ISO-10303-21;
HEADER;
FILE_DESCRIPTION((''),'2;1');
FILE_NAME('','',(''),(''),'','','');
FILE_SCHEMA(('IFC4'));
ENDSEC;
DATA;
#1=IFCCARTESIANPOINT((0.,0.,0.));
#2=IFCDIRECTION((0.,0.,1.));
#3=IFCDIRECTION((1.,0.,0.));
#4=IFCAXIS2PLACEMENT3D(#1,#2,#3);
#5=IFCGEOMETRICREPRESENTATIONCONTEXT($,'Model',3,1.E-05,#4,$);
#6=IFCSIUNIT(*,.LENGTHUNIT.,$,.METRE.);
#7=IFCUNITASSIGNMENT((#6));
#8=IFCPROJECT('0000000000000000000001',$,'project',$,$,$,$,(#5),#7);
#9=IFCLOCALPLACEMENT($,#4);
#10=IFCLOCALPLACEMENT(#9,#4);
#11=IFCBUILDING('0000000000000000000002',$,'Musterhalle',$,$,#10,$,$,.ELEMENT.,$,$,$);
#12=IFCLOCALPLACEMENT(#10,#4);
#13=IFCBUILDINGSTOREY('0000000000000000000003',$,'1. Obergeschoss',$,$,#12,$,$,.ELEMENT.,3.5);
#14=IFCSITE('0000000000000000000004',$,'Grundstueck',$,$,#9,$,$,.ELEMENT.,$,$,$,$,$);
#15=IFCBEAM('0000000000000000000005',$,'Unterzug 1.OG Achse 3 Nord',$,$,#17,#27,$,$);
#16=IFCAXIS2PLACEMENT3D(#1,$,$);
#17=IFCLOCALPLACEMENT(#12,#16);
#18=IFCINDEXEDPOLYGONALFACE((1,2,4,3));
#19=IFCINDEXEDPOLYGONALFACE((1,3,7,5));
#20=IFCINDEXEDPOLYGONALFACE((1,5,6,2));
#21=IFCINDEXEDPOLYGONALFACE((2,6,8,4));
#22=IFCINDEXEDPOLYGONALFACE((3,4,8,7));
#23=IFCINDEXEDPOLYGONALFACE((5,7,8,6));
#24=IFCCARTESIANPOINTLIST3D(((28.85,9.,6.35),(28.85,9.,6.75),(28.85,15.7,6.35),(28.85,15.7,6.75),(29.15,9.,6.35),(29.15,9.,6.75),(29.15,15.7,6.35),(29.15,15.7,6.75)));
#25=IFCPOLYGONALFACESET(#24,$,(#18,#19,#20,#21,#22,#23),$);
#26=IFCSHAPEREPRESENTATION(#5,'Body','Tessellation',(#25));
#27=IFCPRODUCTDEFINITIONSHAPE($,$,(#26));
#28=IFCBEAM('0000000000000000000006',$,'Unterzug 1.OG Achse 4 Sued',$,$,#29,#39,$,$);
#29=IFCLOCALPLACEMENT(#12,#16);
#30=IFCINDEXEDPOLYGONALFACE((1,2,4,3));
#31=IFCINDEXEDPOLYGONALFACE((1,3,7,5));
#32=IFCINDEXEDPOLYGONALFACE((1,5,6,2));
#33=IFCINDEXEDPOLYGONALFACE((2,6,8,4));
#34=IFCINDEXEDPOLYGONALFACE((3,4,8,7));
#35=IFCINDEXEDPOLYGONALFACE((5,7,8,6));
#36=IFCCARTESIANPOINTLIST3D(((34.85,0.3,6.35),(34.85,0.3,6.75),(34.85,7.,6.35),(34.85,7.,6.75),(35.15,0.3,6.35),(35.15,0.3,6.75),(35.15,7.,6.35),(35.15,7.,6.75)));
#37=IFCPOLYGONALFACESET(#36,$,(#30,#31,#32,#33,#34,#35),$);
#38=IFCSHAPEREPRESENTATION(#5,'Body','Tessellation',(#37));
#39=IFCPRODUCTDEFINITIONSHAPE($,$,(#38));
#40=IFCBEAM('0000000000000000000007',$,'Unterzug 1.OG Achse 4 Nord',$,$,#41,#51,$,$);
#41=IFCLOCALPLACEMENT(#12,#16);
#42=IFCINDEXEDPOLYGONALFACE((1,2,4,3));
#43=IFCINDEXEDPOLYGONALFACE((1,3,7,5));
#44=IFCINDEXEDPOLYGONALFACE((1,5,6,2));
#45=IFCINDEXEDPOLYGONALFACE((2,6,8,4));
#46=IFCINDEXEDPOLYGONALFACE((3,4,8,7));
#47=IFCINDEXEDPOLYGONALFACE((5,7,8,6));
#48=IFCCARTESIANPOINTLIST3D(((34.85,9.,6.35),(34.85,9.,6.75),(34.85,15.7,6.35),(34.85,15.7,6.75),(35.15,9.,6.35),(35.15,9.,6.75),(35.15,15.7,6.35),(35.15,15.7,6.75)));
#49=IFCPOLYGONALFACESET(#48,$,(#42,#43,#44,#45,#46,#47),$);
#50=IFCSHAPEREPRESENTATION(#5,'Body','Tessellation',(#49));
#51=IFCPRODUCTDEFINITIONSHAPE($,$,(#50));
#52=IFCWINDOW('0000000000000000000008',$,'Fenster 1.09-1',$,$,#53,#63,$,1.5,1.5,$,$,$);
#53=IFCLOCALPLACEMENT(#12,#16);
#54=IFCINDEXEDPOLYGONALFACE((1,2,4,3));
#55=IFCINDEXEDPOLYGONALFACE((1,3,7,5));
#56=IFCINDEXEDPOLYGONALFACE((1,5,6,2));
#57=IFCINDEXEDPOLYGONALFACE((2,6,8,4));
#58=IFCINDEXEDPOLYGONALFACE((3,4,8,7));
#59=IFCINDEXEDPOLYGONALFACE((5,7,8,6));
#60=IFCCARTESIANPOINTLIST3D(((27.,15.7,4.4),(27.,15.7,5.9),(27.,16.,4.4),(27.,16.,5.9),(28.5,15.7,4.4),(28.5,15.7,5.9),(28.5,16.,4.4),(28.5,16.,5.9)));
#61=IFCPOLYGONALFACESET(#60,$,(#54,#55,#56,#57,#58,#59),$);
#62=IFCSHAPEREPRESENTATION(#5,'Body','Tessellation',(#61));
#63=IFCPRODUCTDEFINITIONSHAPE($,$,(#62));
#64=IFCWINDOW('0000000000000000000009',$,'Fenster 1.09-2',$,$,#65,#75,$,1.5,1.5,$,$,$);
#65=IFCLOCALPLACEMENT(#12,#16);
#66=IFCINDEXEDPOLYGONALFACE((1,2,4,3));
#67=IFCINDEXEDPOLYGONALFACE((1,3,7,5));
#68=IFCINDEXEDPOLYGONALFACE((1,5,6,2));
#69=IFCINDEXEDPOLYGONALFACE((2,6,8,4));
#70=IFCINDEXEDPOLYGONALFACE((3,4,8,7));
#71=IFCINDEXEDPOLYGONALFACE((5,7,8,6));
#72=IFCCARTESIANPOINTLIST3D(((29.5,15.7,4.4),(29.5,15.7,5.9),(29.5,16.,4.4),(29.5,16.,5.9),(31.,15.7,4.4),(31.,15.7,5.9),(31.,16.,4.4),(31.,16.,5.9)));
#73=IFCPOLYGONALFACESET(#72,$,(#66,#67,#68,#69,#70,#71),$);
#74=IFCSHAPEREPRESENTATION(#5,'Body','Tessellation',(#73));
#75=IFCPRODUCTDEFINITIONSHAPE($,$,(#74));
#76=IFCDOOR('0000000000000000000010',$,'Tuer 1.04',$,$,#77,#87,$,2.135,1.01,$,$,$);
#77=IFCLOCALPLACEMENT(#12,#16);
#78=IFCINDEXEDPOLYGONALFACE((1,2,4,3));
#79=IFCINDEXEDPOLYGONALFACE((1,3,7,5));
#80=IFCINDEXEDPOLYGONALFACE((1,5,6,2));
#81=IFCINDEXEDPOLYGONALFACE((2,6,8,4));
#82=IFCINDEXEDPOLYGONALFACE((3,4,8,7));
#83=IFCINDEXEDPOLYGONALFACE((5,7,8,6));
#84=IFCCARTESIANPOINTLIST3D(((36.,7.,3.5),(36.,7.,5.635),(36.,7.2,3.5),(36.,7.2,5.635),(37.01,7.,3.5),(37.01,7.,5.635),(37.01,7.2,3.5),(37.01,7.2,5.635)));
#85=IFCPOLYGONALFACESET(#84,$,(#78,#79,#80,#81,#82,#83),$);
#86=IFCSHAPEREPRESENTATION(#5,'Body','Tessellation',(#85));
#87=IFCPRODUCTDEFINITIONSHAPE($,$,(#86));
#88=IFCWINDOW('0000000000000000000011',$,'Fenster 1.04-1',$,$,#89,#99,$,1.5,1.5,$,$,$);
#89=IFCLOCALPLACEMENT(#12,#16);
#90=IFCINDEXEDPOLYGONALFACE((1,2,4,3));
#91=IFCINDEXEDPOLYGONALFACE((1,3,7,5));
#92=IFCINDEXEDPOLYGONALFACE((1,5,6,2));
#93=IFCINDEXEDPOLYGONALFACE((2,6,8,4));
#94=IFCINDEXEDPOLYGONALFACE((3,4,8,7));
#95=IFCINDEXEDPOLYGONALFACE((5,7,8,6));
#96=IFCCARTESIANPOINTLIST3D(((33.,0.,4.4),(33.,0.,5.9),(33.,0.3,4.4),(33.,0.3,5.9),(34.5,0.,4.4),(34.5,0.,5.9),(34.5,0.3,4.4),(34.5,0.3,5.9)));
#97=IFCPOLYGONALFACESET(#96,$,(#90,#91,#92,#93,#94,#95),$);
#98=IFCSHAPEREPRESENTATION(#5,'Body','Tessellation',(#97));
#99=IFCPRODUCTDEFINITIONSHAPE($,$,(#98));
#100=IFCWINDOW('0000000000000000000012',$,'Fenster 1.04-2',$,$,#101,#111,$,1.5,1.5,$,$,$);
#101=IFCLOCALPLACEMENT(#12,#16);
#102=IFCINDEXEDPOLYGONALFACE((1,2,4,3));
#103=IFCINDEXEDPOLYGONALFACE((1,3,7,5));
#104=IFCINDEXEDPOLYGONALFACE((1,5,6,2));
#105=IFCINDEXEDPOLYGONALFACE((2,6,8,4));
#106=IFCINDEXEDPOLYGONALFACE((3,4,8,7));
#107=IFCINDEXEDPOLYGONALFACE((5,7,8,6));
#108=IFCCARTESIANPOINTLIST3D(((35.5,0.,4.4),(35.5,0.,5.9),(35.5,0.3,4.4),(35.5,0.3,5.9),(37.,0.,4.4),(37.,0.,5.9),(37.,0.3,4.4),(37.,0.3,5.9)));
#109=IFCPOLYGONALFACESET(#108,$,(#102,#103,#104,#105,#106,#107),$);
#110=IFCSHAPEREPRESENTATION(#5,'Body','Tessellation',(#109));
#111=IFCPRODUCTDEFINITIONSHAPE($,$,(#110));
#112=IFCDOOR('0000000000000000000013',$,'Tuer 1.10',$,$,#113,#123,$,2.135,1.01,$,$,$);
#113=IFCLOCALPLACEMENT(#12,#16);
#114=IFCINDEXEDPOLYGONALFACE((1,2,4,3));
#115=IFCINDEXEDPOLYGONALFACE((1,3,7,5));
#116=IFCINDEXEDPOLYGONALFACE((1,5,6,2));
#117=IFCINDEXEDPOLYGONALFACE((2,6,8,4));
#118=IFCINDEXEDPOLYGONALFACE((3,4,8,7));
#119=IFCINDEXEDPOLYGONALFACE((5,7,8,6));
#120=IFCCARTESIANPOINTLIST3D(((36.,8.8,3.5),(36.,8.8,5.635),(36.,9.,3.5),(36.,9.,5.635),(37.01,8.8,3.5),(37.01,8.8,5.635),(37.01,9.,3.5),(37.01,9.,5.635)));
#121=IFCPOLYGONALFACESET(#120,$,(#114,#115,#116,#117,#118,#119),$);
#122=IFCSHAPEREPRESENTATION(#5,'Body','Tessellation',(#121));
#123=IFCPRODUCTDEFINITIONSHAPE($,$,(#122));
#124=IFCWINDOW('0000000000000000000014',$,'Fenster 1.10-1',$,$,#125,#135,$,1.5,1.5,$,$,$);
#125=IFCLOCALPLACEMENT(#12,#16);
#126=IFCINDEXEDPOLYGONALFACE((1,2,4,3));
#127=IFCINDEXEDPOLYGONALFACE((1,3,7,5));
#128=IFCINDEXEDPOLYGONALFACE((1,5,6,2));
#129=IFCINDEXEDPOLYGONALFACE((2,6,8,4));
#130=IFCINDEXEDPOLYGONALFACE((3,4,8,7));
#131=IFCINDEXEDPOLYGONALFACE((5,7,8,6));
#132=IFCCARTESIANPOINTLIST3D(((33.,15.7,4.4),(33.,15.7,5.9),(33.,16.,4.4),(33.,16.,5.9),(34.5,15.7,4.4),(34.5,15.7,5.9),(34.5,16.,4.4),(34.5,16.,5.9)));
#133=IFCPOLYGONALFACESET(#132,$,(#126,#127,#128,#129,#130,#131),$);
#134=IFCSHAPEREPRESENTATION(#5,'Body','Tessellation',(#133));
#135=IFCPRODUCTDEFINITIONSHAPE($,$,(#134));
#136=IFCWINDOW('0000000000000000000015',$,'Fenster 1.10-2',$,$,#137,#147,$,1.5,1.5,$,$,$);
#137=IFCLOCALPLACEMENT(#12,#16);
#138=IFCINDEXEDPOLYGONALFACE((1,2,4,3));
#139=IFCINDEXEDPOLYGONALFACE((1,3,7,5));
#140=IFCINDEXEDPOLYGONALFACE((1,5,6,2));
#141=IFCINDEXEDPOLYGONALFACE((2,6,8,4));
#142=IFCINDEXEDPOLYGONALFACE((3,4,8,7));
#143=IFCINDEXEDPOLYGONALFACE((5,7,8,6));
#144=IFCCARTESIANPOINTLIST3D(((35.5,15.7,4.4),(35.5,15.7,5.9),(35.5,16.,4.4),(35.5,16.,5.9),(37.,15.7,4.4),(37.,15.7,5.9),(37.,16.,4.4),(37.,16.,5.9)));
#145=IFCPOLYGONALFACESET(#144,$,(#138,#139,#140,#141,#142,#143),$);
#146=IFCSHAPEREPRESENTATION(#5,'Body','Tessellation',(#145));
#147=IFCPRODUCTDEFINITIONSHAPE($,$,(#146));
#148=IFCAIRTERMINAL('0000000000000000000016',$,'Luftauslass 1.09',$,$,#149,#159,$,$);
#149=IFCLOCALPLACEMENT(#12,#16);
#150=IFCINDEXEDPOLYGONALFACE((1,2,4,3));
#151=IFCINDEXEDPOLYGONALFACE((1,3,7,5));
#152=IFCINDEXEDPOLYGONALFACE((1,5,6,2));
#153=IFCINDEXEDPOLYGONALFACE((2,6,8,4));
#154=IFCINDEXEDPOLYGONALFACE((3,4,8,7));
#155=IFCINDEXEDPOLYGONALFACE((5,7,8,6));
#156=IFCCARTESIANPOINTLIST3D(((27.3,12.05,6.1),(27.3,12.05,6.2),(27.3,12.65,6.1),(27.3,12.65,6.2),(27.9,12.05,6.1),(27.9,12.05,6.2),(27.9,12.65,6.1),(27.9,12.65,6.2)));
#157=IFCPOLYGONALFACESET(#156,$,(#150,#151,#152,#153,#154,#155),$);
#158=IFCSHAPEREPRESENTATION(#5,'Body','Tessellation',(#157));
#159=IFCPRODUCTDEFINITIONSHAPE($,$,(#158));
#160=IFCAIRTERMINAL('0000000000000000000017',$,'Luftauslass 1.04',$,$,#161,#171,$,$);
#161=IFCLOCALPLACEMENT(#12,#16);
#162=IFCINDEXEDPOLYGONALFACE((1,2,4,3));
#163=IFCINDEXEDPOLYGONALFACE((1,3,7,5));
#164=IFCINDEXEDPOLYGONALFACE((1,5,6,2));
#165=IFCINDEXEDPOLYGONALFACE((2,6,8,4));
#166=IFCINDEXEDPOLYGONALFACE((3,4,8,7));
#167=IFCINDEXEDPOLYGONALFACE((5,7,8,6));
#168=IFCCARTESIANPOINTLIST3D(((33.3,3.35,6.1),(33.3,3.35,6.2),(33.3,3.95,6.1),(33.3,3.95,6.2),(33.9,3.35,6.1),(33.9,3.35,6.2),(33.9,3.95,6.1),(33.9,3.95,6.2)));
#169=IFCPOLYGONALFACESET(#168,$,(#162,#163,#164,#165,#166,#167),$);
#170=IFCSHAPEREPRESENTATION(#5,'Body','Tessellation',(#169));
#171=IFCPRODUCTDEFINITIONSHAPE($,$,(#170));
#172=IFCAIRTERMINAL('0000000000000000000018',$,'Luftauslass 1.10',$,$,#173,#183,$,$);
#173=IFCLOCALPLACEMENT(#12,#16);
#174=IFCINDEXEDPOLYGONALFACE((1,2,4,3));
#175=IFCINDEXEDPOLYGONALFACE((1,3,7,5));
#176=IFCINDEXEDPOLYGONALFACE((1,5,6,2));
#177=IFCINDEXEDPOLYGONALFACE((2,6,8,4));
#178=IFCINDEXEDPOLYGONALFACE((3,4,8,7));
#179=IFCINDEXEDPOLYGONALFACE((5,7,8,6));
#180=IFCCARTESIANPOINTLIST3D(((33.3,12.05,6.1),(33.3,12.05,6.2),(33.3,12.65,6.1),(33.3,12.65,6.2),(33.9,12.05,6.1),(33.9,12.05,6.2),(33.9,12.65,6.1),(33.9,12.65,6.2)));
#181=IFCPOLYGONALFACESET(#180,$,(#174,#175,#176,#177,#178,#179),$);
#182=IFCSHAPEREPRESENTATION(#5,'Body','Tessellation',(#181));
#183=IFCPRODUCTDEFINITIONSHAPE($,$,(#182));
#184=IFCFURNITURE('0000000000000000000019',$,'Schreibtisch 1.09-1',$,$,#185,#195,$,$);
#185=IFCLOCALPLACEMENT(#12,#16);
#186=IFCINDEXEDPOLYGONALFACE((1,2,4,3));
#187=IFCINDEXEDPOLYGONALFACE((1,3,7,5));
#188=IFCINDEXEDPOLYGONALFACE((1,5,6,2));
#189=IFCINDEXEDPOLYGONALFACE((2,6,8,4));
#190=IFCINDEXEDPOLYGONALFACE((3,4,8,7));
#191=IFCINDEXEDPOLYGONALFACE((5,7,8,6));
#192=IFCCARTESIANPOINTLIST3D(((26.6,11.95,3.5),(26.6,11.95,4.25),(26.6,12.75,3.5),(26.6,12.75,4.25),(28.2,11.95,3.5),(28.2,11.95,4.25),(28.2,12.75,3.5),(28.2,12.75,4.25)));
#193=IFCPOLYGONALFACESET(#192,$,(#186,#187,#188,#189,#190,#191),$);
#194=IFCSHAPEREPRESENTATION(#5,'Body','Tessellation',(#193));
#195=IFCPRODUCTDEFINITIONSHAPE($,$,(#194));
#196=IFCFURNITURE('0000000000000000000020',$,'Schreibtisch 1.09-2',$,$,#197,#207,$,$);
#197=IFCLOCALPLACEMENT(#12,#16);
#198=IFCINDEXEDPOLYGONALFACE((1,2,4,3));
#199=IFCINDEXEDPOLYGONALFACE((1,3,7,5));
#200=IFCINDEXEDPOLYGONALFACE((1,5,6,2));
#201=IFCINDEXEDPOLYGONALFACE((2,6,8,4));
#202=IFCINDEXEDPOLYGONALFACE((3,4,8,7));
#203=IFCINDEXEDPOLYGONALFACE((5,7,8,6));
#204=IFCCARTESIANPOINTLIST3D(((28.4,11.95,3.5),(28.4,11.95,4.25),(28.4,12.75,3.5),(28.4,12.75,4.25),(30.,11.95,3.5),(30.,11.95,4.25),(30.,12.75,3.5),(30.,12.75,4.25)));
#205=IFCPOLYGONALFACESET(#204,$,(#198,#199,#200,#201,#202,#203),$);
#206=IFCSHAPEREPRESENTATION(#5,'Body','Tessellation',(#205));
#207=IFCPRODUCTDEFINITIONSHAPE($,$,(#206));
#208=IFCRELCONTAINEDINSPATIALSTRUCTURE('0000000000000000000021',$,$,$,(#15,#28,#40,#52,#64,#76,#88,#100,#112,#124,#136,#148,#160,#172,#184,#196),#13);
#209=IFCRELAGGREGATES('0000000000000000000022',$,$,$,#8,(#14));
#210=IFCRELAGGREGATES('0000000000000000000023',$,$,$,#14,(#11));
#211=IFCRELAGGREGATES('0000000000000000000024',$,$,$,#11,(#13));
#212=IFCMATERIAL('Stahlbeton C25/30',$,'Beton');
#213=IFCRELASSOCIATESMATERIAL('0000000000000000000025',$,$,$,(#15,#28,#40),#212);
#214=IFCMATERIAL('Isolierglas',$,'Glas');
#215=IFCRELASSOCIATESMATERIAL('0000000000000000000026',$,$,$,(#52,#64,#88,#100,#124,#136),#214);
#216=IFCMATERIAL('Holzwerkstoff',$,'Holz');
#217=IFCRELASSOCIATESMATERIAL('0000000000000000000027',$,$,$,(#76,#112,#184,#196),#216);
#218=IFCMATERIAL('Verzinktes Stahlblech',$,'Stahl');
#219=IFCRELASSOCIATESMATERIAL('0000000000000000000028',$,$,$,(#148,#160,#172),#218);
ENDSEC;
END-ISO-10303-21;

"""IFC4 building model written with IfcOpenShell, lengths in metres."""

from ifc_helpers import new_model, si_unit, frame, origin_with_axes, origin_2d, place, context, project, spatial, rectangle, extrude, material, element, save


model = new_model("IFC4")

# Units and contexts
model_context = context("Model", 3, precision=1e-05, world=origin_with_axes())
ifc_project = project(units=[si_unit("LENGTHUNIT", "METRE")], contexts=[model_context])

# Site, building, storey
site_placement = place(None, origin_with_axes())
site = spatial("IfcSite", under=ifc_project, at=site_placement, Name="Grundstueck", CompositionType="ELEMENT")
building_placement = place(site_placement, origin_with_axes())
building = spatial("IfcBuilding", under=site, at=building_placement, Name="Musterhalle", CompositionType="ELEMENT")
storey_placement = place(building_placement, origin_with_axes())
storey = spatial("IfcBuildingStorey", under=building, at=storey_placement, Name="1. Obergeschoss", CompositionType="ELEMENT", Elevation=3.5)

# Beams
ifc_material_1 = material(Name="Stahlbeton C25/30", Category="Beton")
placement = place(storey_placement, origin_with_axes())
element("IfcBeam", 1, at=placement, inside=storey, material=ifc_material_1, Name="Unterzug 1.OG Achse 3 Nord", context=model_context, shape_type="SweptSolid", body=[
    extrude(rectangle(XDim=0.3, YDim=6.7, at=origin_2d()), frame((29.0, 12.35, 6.35), z_axis=(0.0, 0.0, 1.0), x_axis=(1.0, 0.0, 0.0)), (0.0, 0.0, 1.0), 0.4),
])
element("IfcBeam", 2, at=placement, inside=storey, material=ifc_material_1, Name="Unterzug 1.OG Achse 4 Sued", context=model_context, shape_type="SweptSolid", body=[
    extrude(rectangle(XDim=0.3, YDim=6.7, at=origin_2d()), frame((35.0, 3.65, 6.35), z_axis=(0.0, 0.0, 1.0), x_axis=(1.0, 0.0, 0.0)), (0.0, 0.0, 1.0), 0.4),
])
element("IfcBeam", 3, at=placement, inside=storey, material=ifc_material_1, Name="Unterzug 1.OG Achse 4 Nord", context=model_context, shape_type="SweptSolid", body=[
    extrude(rectangle(XDim=0.3, YDim=6.7, at=origin_2d()), frame((35.0, 12.35, 6.35), z_axis=(0.0, 0.0, 1.0), x_axis=(1.0, 0.0, 0.0)), (0.0, 0.0, 1.0), 0.4),
])

# Windows
ifc_material_2 = material(Name="Isolierglas", Category="Glas")
element("IfcWindow", 4, at=placement, inside=storey, material=ifc_material_2, Name="Fenster 1.09-1", OverallHeight=1.5, OverallWidth=1.5, context=model_context, shape_type="SweptSolid", body=[
    extrude(rectangle(XDim=1.5, YDim=0.3, at=origin_2d()), frame((27.75, 15.85, 4.4), z_axis=(0.0, 0.0, 1.0), x_axis=(1.0, 0.0, 0.0)), (0.0, 0.0, 1.0), 1.5),
])
element("IfcWindow", 5, at=placement, inside=storey, material=ifc_material_2, Name="Fenster 1.09-2", OverallHeight=1.5, OverallWidth=1.5, context=model_context, shape_type="SweptSolid", body=[
    extrude(rectangle(XDim=1.5, YDim=0.3, at=origin_2d()), frame((30.25, 15.85, 4.4), z_axis=(0.0, 0.0, 1.0), x_axis=(1.0, 0.0, 0.0)), (0.0, 0.0, 1.0), 1.5),
])

# Door
ifc_material_3 = material(Name="Holzwerkstoff", Category="Holz")
element("IfcDoor", 6, at=placement, inside=storey, material=ifc_material_3, Name="Tuer 1.04", OverallHeight=2.135, OverallWidth=1.01, context=model_context, shape_type="SweptSolid", body=[
    extrude(rectangle(XDim=1.01, YDim=0.2, at=origin_2d()), frame((36.505, 7.1, 3.5), z_axis=(0.0, 0.0, 1.0), x_axis=(1.0, 0.0, 0.0)), (0.0, 0.0, 1.0), 2.135),
])

# Windows
element("IfcWindow", 7, at=placement, inside=storey, material=ifc_material_2, Name="Fenster 1.04-1", OverallHeight=1.5, OverallWidth=1.5, context=model_context, shape_type="SweptSolid", body=[
    extrude(rectangle(XDim=1.5, YDim=0.3, at=origin_2d()), frame((33.75, 0.15, 4.4), z_axis=(0.0, 0.0, 1.0), x_axis=(1.0, 0.0, 0.0)), (0.0, 0.0, 1.0), 1.5),
])
element("IfcWindow", 8, at=placement, inside=storey, material=ifc_material_2, Name="Fenster 1.04-2", OverallHeight=1.5, OverallWidth=1.5, context=model_context, shape_type="SweptSolid", body=[
    extrude(rectangle(XDim=1.5, YDim=0.3, at=origin_2d()), frame((36.25, 0.15, 4.4), z_axis=(0.0, 0.0, 1.0), x_axis=(1.0, 0.0, 0.0)), (0.0, 0.0, 1.0), 1.5),
])

# Door
element("IfcDoor", 9, at=placement, inside=storey, material=ifc_material_3, Name="Tuer 1.10", OverallHeight=2.135, OverallWidth=1.01, context=model_context, shape_type="SweptSolid", body=[
    extrude(rectangle(XDim=1.01, YDim=0.2, at=origin_2d()), frame((36.505, 8.9, 3.5), z_axis=(0.0, 0.0, 1.0), x_axis=(1.0, 0.0, 0.0)), (0.0, 0.0, 1.0), 2.135),
])

# Windows
element("IfcWindow", 10, at=placement, inside=storey, material=ifc_material_2, Name="Fenster 1.10-1", OverallHeight=1.5, OverallWidth=1.5, context=model_context, shape_type="SweptSolid", body=[
    extrude(rectangle(XDim=1.5, YDim=0.3, at=origin_2d()), frame((33.75, 15.85, 4.4), z_axis=(0.0, 0.0, 1.0), x_axis=(1.0, 0.0, 0.0)), (0.0, 0.0, 1.0), 1.5),
])
element("IfcWindow", 11, at=placement, inside=storey, material=ifc_material_2, Name="Fenster 1.10-2", OverallHeight=1.5, OverallWidth=1.5, context=model_context, shape_type="SweptSolid", body=[
    extrude(rectangle(XDim=1.5, YDim=0.3, at=origin_2d()), frame((36.25, 15.85, 4.4), z_axis=(0.0, 0.0, 1.0), x_axis=(1.0, 0.0, 0.0)), (0.0, 0.0, 1.0), 1.5),
])

# Air terminals
ifc_material_4 = material(Name="Verzinktes Stahlblech", Category="Stahl")
element("IfcAirTerminal", 12, at=placement, inside=storey, material=ifc_material_4, Name="Luftauslass 1.09", context=model_context, shape_type="SweptSolid", body=[
    extrude(rectangle(XDim=0.6, YDim=0.6, at=origin_2d()), frame((27.6, 12.35, 6.1), z_axis=(0.0, 0.0, 1.0), x_axis=(1.0, 0.0, 0.0)), (0.0, 0.0, 1.0), 0.1),
])
element("IfcAirTerminal", 13, at=placement, inside=storey, material=ifc_material_4, Name="Luftauslass 1.04", context=model_context, shape_type="SweptSolid", body=[
    extrude(rectangle(XDim=0.6, YDim=0.6, at=origin_2d()), frame((33.6, 3.65, 6.1), z_axis=(0.0, 0.0, 1.0), x_axis=(1.0, 0.0, 0.0)), (0.0, 0.0, 1.0), 0.1),
])
element("IfcAirTerminal", 14, at=placement, inside=storey, material=ifc_material_4, Name="Luftauslass 1.10", context=model_context, shape_type="SweptSolid", body=[
    extrude(rectangle(XDim=0.6, YDim=0.6, at=origin_2d()), frame((33.6, 12.35, 6.1), z_axis=(0.0, 0.0, 1.0), x_axis=(1.0, 0.0, 0.0)), (0.0, 0.0, 1.0), 0.1),
])

# Furniture
element("IfcFurniture", 15, at=placement, inside=storey, material=ifc_material_3, Name="Schreibtisch 1.09-1", context=model_context, shape_type="SweptSolid", body=[
    extrude(rectangle(XDim=1.6, YDim=0.8, at=origin_2d()), frame((27.4, 12.35, 3.5), z_axis=(0.0, 0.0, 1.0), x_axis=(1.0, 0.0, 0.0)), (0.0, 0.0, 1.0), 0.75),
])
element("IfcFurniture", 16, at=placement, inside=storey, material=ifc_material_3, Name="Schreibtisch 1.09-2", context=model_context, shape_type="SweptSolid", body=[
    extrude(rectangle(XDim=1.6, YDim=0.8, at=origin_2d()), frame((29.2, 12.35, 3.5), z_axis=(0.0, 0.0, 1.0), x_axis=(1.0, 0.0, 0.0)), (0.0, 0.0, 1.0), 0.75),
])

save(model, "model.ifc")
